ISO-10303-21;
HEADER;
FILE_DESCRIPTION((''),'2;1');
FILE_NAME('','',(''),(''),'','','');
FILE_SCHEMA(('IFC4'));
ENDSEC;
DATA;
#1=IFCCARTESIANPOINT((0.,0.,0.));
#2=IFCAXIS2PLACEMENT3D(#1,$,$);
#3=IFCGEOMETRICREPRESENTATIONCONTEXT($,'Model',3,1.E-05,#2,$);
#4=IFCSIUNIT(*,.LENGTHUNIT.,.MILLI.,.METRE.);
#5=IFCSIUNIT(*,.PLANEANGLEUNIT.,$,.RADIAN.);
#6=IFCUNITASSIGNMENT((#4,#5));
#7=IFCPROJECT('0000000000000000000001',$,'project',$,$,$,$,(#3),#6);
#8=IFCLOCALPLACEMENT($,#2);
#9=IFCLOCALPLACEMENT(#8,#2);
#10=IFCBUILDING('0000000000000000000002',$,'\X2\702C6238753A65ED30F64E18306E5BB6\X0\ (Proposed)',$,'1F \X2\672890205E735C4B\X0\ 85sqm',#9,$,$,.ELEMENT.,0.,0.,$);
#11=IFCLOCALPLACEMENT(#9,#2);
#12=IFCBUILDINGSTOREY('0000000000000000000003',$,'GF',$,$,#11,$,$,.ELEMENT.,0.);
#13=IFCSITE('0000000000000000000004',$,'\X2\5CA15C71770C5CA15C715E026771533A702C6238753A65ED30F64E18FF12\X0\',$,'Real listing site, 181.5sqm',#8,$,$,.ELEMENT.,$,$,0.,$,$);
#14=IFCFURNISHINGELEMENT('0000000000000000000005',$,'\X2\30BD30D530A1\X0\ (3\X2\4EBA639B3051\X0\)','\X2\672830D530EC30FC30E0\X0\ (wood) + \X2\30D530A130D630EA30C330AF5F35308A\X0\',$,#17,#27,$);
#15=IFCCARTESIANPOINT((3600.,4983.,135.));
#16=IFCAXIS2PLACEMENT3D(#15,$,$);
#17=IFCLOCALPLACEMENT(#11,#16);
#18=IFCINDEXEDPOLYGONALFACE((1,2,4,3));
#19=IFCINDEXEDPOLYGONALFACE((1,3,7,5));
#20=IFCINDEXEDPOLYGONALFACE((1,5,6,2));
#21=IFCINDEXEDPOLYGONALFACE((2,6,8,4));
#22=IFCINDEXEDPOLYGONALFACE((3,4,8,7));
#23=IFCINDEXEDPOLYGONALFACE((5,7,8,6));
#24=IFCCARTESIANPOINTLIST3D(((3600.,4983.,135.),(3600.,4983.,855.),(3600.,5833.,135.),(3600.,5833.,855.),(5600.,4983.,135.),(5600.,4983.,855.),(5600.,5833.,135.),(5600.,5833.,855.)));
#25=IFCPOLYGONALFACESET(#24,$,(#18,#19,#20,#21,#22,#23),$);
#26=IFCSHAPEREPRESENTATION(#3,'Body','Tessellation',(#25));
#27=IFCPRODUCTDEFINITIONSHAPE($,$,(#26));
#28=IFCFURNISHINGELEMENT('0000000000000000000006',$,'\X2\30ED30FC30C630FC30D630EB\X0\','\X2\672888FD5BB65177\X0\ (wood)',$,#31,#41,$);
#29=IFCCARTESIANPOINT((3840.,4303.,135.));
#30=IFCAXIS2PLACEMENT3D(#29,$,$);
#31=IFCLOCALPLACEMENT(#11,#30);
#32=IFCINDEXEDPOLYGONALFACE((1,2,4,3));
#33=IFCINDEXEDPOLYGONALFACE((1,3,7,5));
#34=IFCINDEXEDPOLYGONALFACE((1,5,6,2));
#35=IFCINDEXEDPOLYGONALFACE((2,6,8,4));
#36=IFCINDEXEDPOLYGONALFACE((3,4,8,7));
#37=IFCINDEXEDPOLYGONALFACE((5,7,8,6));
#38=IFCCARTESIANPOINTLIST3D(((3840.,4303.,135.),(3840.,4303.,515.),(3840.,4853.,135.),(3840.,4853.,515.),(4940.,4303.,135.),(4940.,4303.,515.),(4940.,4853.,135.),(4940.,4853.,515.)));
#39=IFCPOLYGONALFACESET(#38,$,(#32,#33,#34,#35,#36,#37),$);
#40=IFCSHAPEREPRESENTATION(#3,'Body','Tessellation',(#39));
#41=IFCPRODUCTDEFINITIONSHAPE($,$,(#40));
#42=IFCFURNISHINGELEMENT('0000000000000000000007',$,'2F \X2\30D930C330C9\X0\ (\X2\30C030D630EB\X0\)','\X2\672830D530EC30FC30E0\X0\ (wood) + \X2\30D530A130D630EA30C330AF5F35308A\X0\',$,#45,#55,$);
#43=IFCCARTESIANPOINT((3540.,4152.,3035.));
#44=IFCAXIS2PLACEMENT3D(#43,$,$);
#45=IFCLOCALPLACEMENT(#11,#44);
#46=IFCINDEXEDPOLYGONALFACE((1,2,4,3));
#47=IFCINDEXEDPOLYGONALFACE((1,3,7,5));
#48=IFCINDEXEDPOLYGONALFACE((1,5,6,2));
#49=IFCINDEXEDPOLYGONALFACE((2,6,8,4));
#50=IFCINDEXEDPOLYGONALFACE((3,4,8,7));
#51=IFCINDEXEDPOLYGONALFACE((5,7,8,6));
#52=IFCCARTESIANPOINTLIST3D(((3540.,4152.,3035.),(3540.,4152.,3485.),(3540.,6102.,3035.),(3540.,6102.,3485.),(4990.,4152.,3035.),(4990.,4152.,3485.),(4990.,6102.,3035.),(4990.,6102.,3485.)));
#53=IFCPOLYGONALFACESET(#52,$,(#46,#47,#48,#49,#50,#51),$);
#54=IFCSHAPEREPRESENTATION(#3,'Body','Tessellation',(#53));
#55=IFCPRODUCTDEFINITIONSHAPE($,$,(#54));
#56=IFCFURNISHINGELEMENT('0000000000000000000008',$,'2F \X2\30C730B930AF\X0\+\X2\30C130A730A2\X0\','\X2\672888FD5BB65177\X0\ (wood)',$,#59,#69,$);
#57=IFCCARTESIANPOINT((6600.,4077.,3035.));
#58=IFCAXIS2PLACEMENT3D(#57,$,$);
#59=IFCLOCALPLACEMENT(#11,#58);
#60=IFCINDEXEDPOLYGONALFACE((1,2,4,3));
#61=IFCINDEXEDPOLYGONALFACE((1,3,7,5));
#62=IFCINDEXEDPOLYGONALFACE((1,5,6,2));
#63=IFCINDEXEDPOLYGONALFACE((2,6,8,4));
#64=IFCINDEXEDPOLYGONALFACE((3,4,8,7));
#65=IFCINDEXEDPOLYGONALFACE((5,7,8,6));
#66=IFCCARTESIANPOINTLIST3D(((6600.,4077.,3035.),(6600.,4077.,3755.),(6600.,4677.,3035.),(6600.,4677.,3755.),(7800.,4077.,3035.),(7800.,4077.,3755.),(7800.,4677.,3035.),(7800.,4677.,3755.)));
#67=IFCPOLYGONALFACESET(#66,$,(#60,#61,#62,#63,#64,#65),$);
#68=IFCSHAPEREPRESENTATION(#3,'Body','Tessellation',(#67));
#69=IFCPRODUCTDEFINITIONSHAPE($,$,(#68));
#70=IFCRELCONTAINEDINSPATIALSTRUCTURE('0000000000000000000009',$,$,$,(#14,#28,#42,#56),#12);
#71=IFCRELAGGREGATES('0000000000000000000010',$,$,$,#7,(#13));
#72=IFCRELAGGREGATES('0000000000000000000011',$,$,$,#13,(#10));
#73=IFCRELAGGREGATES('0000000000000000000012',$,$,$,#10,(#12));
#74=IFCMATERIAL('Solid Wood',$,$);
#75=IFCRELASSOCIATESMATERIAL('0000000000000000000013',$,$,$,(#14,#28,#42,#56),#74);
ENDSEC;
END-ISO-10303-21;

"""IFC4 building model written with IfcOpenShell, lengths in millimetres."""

from ifc_helpers import new_model, si_unit, frame, frame_2d, origin, place, context, project, spatial, rectangle, extrude, material, element, save


model = new_model("IFC4")

# Units and contexts
model_context = context("Model", 3, precision=1e-05, world=origin())
ifc_project = project(units=[si_unit("LENGTHUNIT", "METRE", prefix="MILLI"), si_unit("PLANEANGLEUNIT", "RADIAN")], contexts=[model_context])

# Site, building, storey
site_placement = place(None, origin())
site = spatial("IfcSite", under=ifc_project, at=site_placement, Name="岡山県岡山市東区瀬戸町旭ヶ丘２", ObjectType="Real listing site, 181.5sqm", CompositionType="ELEMENT", RefElevation=0.0)
building_placement = place(site_placement, origin())
building = spatial("IfcBuilding", under=site, at=building_placement, Name="瀬戸町旭ヶ丘の家 (Proposed)", ObjectType="1F 木造平屋 85sqm", CompositionType="ELEMENT", ElevationOfRefHeight=0.0, ElevationOfTerrain=0.0)
storey_placement = place(building_placement, origin())
storey = spatial("IfcBuildingStorey", under=building, at=storey_placement, Name="GF", CompositionType="ELEMENT", Elevation=0.0)

# Shared definitions
ifc_material_1 = material(Name="Solid Wood")

# Furnishing elements
furnishing_1_placement = place(storey_placement, frame((3600.0, 4983.0, 135.0)))
element("IfcFurnishingElement", 1, at=furnishing_1_placement, inside=storey, material=ifc_material_1, Name="ソファ (3人掛け)", Description="木フレーム (wood) + ファブリック張り", context=model_context, shape_type="SweptSolid", body=[
    extrude(rectangle(XDim=2000.0, YDim=850.0, at=frame_2d((1000.0, 425.0))), frame((3600.0, 4983.0, 135.0)), (0.0, 0.0, 1.0), 720.0),
])
furnishing_2_placement = place(storey_placement, frame((3840.0, 4303.0, 135.0)))
element("IfcFurnishingElement", 2, at=furnishing_2_placement, inside=storey, material=ifc_material_1, Name="ローテーブル", Description="木製家具 (wood)", context=model_context, shape_type="SweptSolid", body=[
    extrude(rectangle(XDim=1100.0, YDim=550.0, at=frame_2d((550.0, 275.0))), frame((3840.0, 4303.0, 135.0)), (0.0, 0.0, 1.0), 380.0),
])
furnishing_3_placement = place(storey_placement, frame((3540.0, 4152.0, 3035.0)))
element("IfcFurnishingElement", 3, at=furnishing_3_placement, inside=storey, material=ifc_material_1, Name="2F ベッド (ダブル)", Description="木フレーム (wood) + ファブリック張り", context=model_context, shape_type="SweptSolid", body=[
    extrude(rectangle(XDim=1450.0, YDim=1950.0, at=frame_2d((725.0, 975.0))), frame((3540.0, 4152.0, 3035.0)), (0.0, 0.0, 1.0), 450.0),
])
furnishing_4_placement = place(storey_placement, frame((6600.0, 4077.0, 3035.0)))
element("IfcFurnishingElement", 4, at=furnishing_4_placement, inside=storey, material=ifc_material_1, Name="2F デスク+チェア", Description="木製家具 (wood)", context=model_context, shape_type="SweptSolid", body=[
    extrude(rectangle(XDim=1200.0, YDim=600.0, at=frame_2d((600.0, 300.0))), frame((6600.0, 4077.0, 3035.0)), (0.0, 0.0, 1.0), 720.0),
])

save(model, "model.ifc")
